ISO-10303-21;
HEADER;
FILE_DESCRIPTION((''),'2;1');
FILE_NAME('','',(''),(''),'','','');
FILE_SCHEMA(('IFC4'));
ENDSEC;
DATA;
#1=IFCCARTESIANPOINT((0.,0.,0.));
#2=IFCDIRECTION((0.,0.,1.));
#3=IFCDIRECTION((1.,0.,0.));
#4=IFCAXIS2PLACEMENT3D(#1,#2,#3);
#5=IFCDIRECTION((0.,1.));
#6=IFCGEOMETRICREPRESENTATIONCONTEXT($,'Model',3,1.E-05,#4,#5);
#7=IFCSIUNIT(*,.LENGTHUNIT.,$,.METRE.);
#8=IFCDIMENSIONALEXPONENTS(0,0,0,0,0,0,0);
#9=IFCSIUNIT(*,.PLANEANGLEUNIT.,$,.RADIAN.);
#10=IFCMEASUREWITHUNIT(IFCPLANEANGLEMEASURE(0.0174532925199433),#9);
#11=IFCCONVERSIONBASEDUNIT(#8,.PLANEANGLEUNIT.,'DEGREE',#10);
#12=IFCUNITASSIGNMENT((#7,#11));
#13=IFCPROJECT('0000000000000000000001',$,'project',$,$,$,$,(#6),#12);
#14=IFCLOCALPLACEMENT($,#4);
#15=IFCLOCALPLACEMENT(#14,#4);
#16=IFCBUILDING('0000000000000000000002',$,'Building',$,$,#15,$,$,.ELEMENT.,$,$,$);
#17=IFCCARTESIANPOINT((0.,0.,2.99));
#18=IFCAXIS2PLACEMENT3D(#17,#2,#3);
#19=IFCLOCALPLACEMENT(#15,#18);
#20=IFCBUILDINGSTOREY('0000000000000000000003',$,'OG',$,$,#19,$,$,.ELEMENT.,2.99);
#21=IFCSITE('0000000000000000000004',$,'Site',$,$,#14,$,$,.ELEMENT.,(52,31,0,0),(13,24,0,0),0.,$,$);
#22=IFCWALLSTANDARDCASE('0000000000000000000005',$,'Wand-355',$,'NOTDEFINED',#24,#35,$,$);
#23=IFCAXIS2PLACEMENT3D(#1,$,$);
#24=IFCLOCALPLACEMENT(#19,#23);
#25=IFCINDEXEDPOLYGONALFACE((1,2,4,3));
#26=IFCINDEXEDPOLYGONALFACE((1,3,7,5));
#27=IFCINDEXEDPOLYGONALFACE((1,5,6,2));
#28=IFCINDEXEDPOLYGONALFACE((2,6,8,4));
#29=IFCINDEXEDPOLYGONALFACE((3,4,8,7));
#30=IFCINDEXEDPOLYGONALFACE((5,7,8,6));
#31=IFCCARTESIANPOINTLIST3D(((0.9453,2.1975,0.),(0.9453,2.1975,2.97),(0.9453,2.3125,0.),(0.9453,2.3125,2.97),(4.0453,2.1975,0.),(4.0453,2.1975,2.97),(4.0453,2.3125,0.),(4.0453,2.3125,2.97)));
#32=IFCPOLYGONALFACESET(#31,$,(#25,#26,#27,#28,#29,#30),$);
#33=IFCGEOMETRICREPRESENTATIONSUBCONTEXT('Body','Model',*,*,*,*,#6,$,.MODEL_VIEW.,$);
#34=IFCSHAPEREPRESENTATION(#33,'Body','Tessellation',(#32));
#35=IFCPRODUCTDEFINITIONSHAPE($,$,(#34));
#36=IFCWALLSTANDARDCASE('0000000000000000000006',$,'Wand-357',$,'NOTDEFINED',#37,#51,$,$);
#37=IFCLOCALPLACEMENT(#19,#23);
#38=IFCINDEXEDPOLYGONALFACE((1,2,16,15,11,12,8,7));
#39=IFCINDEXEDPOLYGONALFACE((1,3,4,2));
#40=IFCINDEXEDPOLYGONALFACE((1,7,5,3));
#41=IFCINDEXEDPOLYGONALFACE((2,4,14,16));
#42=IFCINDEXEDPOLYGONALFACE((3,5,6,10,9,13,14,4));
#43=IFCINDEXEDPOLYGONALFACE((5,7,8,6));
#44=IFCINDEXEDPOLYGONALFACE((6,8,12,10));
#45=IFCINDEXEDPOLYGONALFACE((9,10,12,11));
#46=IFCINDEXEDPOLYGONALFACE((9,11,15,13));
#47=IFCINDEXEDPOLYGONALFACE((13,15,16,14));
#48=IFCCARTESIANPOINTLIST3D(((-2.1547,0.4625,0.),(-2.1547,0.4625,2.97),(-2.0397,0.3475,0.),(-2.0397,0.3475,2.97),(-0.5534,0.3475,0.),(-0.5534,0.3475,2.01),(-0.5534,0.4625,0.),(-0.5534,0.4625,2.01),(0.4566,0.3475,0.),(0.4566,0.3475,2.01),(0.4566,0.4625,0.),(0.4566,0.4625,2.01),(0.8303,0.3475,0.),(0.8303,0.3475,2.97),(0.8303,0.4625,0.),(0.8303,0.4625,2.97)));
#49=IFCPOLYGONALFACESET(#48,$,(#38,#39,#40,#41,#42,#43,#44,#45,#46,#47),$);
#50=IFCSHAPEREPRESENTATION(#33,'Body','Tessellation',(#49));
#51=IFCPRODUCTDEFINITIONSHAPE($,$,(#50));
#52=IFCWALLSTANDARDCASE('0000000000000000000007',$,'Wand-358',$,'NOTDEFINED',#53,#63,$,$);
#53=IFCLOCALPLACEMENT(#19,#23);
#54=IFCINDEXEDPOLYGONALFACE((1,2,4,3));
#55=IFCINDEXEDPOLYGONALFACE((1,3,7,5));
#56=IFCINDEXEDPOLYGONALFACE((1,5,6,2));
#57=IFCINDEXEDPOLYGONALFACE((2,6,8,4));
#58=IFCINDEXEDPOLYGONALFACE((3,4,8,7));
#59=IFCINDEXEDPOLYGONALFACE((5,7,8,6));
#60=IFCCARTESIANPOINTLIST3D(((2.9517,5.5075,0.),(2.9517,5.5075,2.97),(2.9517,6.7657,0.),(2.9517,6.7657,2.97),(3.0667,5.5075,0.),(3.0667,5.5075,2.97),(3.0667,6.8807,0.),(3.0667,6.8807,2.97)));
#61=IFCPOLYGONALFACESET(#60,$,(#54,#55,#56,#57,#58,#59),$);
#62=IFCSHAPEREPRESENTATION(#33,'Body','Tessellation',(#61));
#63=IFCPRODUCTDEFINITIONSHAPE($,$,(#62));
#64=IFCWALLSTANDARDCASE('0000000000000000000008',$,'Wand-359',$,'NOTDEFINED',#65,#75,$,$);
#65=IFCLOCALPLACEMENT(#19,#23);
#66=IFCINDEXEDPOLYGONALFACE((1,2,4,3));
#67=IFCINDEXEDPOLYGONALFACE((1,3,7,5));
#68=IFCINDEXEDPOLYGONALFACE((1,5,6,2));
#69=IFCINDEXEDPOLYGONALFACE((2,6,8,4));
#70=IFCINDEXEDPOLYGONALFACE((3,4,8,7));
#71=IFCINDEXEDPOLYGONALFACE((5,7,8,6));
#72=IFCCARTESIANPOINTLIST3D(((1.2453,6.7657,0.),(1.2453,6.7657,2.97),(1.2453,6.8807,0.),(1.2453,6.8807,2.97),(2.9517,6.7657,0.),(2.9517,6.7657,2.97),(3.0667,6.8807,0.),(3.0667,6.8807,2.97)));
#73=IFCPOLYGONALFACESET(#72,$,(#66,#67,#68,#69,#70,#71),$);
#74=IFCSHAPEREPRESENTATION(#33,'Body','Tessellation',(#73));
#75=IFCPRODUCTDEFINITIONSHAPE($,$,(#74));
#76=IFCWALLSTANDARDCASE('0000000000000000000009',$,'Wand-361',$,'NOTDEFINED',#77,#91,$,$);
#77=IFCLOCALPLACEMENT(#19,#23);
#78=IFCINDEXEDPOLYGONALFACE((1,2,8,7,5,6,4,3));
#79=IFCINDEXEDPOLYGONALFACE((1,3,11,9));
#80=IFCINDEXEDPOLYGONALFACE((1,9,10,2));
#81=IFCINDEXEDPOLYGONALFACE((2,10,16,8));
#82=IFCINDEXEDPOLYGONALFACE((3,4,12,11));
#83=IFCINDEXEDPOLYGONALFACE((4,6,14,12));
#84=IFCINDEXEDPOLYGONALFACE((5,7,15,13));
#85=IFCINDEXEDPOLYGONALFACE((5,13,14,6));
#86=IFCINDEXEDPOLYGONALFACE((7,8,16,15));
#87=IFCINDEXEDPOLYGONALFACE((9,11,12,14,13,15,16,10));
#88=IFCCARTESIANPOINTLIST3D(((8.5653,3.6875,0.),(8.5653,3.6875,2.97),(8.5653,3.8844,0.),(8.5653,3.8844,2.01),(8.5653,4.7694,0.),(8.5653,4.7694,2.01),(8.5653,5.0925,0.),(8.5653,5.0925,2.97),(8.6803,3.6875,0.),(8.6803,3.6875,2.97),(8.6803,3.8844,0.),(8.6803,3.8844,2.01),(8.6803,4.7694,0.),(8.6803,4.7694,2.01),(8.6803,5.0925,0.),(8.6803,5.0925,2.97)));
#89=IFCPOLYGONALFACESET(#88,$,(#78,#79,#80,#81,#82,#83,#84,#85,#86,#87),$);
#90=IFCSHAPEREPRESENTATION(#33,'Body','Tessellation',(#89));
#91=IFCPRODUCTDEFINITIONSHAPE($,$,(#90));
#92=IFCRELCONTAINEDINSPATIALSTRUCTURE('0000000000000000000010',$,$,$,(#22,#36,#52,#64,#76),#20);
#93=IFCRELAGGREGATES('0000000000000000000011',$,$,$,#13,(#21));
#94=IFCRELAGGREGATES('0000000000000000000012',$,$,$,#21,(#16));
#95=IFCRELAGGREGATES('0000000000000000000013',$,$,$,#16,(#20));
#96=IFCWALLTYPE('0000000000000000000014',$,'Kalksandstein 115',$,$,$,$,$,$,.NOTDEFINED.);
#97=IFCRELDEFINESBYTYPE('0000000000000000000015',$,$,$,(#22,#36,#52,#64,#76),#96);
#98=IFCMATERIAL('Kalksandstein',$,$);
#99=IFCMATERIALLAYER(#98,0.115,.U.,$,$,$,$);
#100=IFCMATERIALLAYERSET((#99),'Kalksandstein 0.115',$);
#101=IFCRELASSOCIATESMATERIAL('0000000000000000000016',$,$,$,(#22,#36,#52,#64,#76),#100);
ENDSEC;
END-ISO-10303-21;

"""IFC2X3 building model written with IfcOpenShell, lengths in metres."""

from ifc_helpers import new_model, entity, si_unit, converted_unit, direction, frame, origin_with_axes, origin_2d_with_axis, place, context, subcontext, project, spatial, polyline, rectangle, outline, extrude, material, layer, layer_set, layer_usage, type_object, element, save


model = new_model("IFC2X3")

# Units and contexts
model_context = context("Model", 3, precision=1e-05, world=origin_with_axes(), true_north=direction((0.0, 1.0)))
body_context = subcontext(model_context, "Body", "Model", "MODEL_VIEW")
ifc_project = project(units=[si_unit("LENGTHUNIT", "METRE"), converted_unit("PLANEANGLEUNIT", "DEGREE", entity("IfcPlaneAngleMeasure", 0.0174532925199433), si_unit("PLANEANGLEUNIT", "RADIAN"), dimensions=[0, 0, 0, 0, 0, 0, 0])], contexts=[model_context])

# Site, building, storey
site_placement = place(None, origin_with_axes())
site = spatial("IfcSite", under=ifc_project, at=site_placement, Name="Site", CompositionType="ELEMENT", RefLatitude=(52, 31, 0, 0), RefLongitude=(13, 24, 0, 0), RefElevation=0.0)
building_placement = place(site_placement, origin_with_axes())
building = spatial("IfcBuilding", under=site, at=building_placement, Name="Building", CompositionType="ELEMENT")
storey_placement = place(building_placement, frame((0.0, 0.0, 2.99), z_axis=(0.0, 0.0, 1.0), x_axis=(1.0, 0.0, 0.0)))
storey = spatial("IfcBuildingStorey", under=building, at=storey_placement, Name="OG", CompositionType="ELEMENT", Elevation=2.99)

# Shared definitions
ifc_material = material(Name="Kalksandstein")

# Shared definitions
ifc_layer_1 = layer(ifc_material, 0.115, ventilated="UNKNOWN")
ifc_layer_set_1 = layer_set([ifc_layer_1], Name="Kalksandstein 0.115")
wall_type_1 = type_object("IfcWallType", Name="Kalksandstein 115", PredefinedType="NOTDEFINED")

# Wall
ifc_layer_usage_1 = layer_usage(ifc_layer_set_1, "AXIS2", "POSITIVE", -0.115)
wall_1_placement = place(storey_placement, frame((0.8303, 2.3125, 0.0), z_axis=(0.0, 0.0, 1.0), x_axis=(1.0, 0.0, 0.0)))
element("IfcWallStandardCase", 1, at=wall_1_placement, inside=storey, type_object=wall_type_1, material=ifc_layer_usage_1, Name="Wand-355", ObjectType="NOTDEFINED", context=body_context, shape_type="SweptSolid", body=[
    extrude(outline(polyline([(0.115, -0.115), (3.215, -0.115), (3.215, 0.0), (0.115, 0.0), (0.115, -0.115)])), origin_with_axes(), (0.0, 0.0, 1.0), 2.97),
])

# Wall, opening
ifc_layer_usage_2 = layer_usage(ifc_layer_set_1, "AXIS2", "POSITIVE", -0.115)
wall_2_placement = place(storey_placement, frame((-2.1547, 0.4625, 0.0), z_axis=(0.0, 0.0, 1.0), x_axis=(1.0, 0.0, 0.0)))
wall_2 = element("IfcWallStandardCase", 2, at=wall_2_placement, inside=storey, type_object=wall_type_1, material=ifc_layer_usage_2, Name="Wand-357", ObjectType="NOTDEFINED", context=body_context, shape_type="SweptSolid", body=[
    extrude(outline(polyline([(0.115, -0.115), (2.985, -0.115), (2.985, 0.0), (0.0, 0.0), (0.115, -0.115)])), origin_with_axes(), (0.0, 0.0, 1.0), 2.97),
])
opening_1_placement = place(wall_2_placement, frame((2.1063, 0.0, 0.0), z_axis=(0.0, 0.0, 1.0), x_axis=(1.0, 0.0, 0.0)))
element("IfcOpeningElement", 3, at=opening_1_placement, cuts=wall_2, context=body_context, shape_type="SweptSolid", body=[
    extrude(rectangle(XDim=1.01, YDim=2.01, at=origin_2d_with_axis()), frame((0.0, -0.115, 1.005), z_axis=(0.0, 1.0, 0.0), x_axis=(1.0, 0.0, 0.0)), (0.0, 0.0, 1.0), 0.345),
])

# Walls
ifc_layer_usage_3 = layer_usage(ifc_layer_set_1, "AXIS2", "NEGATIVE", 0.115)
wall_3_placement = place(storey_placement, frame((3.0667, 5.5075, 0.0), z_axis=(0.0, 0.0, 1.0), x_axis=(0.0, 1.0, 0.0)))
element("IfcWallStandardCase", 4, at=wall_3_placement, inside=storey, type_object=wall_type_1, material=ifc_layer_usage_3, Name="Wand-358", ObjectType="NOTDEFINED", context=body_context, shape_type="SweptSolid", body=[
    extrude(outline(polyline([(0.0, 0.0), (1.3732, 0.0), (1.2582, 0.115), (0.0, 0.115), (0.0, 0.0)])), origin_with_axes(), (0.0, 0.0, 1.0), 2.97),
])
ifc_layer_usage_4 = layer_usage(ifc_layer_set_1, "AXIS2", "NEGATIVE", 0.115)
wall_4_placement = place(storey_placement, frame((3.0667, 6.8807, 0.0), z_axis=(0.0, 0.0, 1.0), x_axis=(-1.0, 0.0, 0.0)))
element("IfcWallStandardCase", 5, at=wall_4_placement, inside=storey, type_object=wall_type_1, material=ifc_layer_usage_4, Name="Wand-359", ObjectType="NOTDEFINED", context=body_context, shape_type="SweptSolid", body=[
    extrude(outline(polyline([(0.0, 0.0), (1.8214, 0.0), (1.8214, 0.115), (0.115, 0.115), (0.0, 0.0)])), origin_with_axes(), (0.0, 0.0, 1.0), 2.97),
])

# Wall, opening
ifc_layer_usage_5 = layer_usage(ifc_layer_set_1, "AXIS2", "NEGATIVE", 0.115)
wall_5_placement = place(storey_placement, frame((8.6803, 3.6875, 0.0), z_axis=(0.0, 0.0, 1.0), x_axis=(0.0, 1.0, 0.0)))
wall_5 = element("IfcWallStandardCase", 6, at=wall_5_placement, inside=storey, type_object=wall_type_1, material=ifc_layer_usage_5, Name="Wand-361", ObjectType="NOTDEFINED", context=body_context, shape_type="SweptSolid", body=[
    extrude(outline(polyline([(0.0, 0.0), (1.405, 0.0), (1.405, 0.115), (0.0, 0.115), (0.0, 0.0)])), origin_with_axes(), (0.0, 0.0, 1.0), 2.97),
])
opening_2_placement = place(wall_5_placement, frame((0.6394, 0.0, 0.0), z_axis=(0.0, 0.0, 1.0), x_axis=(1.0, 0.0, 0.0)))
element("IfcOpeningElement", 7, at=opening_2_placement, cuts=wall_5, context=body_context, shape_type="SweptSolid", body=[
    extrude(rectangle(XDim=0.885, YDim=2.01, at=origin_2d_with_axis()), frame((0.0, -0.115, 1.005), z_axis=(0.0, -1.0, 0.0), x_axis=(-1.0, 0.0, 0.0)), (0.0, 0.0, -1.0), 0.345),
])

save(model, "model.ifc")
